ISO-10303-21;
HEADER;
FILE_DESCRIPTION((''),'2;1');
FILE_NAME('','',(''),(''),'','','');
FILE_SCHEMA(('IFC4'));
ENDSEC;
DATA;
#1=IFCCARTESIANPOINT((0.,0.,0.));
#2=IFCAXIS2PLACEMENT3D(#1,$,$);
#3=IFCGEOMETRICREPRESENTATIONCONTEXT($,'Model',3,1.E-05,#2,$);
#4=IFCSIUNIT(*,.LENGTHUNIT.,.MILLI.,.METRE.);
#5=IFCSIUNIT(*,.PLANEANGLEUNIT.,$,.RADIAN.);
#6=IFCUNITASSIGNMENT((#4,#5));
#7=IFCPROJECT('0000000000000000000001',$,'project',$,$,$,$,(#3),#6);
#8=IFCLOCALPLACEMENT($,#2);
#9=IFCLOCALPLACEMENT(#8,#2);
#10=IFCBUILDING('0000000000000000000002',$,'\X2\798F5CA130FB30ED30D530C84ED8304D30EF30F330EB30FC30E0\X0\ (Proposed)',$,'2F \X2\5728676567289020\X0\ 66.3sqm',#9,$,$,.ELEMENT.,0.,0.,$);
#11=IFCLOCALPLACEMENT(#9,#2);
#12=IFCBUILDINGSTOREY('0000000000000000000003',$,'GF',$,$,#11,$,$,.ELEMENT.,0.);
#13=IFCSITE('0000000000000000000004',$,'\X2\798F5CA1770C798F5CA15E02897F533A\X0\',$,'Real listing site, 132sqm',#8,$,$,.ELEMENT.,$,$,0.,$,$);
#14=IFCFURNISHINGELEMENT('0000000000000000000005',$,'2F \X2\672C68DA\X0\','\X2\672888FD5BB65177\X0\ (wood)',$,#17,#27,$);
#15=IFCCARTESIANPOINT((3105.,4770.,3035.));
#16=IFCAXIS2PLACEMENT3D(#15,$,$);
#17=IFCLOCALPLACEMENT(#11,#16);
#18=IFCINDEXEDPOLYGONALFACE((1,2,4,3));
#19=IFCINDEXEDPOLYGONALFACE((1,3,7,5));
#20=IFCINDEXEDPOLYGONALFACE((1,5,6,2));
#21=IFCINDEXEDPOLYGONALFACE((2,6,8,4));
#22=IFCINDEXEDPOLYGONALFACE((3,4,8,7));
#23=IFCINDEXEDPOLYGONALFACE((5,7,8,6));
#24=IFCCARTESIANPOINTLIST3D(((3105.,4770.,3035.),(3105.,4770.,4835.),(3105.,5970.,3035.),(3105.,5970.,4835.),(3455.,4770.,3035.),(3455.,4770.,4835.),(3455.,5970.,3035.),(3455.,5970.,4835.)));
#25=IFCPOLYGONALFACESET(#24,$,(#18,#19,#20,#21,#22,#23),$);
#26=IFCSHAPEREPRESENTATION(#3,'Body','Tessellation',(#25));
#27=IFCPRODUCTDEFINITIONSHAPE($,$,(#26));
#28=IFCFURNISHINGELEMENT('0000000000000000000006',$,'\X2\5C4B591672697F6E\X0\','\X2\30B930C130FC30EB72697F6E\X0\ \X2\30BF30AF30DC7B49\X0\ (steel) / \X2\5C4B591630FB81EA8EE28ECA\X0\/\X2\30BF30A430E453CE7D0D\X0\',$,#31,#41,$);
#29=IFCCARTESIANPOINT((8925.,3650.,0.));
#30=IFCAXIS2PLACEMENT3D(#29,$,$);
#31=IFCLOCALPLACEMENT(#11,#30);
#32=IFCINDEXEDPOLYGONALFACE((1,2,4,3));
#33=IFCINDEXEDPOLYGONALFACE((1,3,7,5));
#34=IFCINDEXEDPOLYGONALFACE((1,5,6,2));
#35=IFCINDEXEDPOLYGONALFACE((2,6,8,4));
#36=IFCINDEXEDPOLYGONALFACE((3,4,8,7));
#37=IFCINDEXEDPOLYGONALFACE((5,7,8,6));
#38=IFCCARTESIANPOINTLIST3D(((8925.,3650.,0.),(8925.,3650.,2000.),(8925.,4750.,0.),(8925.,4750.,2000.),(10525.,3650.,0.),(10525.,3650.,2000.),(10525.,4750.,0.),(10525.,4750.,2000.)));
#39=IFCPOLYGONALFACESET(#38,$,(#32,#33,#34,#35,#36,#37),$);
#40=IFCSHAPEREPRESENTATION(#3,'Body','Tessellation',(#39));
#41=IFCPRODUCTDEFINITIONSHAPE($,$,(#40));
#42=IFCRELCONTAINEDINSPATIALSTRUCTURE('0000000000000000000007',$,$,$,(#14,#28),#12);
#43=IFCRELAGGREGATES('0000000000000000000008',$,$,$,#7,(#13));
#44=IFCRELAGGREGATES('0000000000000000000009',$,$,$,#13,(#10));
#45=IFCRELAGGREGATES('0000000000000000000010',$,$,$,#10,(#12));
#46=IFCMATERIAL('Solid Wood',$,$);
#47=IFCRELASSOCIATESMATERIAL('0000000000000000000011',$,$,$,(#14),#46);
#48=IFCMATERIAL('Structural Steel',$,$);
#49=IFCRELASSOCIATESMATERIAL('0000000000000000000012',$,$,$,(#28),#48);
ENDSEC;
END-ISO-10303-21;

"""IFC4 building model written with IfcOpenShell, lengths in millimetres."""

from ifc_helpers import new_model, si_unit, frame, frame_2d, origin, place, context, project, spatial, rectangle, extrude, material, element, save


model = new_model("IFC4")

# Units and contexts
model_context = context("Model", 3, precision=1e-05, world=origin())
ifc_project = project(units=[si_unit("LENGTHUNIT", "METRE", prefix="MILLI"), si_unit("PLANEANGLEUNIT", "RADIAN")], contexts=[model_context])

# Site, building, storey
site_placement = place(None, origin())
site = spatial("IfcSite", under=ifc_project, at=site_placement, Name="福岡県福岡市西区", ObjectType="Real listing site, 132sqm", CompositionType="ELEMENT", RefElevation=0.0)
building_placement = place(site_placement, origin())
building = spatial("IfcBuilding", under=site, at=building_placement, Name="福岡・ロフト付きワンルーム (Proposed)", ObjectType="2F 在来木造 66.3sqm", CompositionType="ELEMENT", ElevationOfRefHeight=0.0, ElevationOfTerrain=0.0)
storey_placement = place(building_placement, origin())
storey = spatial("IfcBuildingStorey", under=building, at=storey_placement, Name="GF", CompositionType="ELEMENT", Elevation=0.0)

# Shared definitions
ifc_material_1 = material(Name="Solid Wood")

# Shared definitions
ifc_material_2 = material(Name="Structural Steel")

# Furnishing elements
furnishing_1_placement = place(storey_placement, frame((3105.0, 4770.0, 3035.0)))
element("IfcFurnishingElement", 1, at=furnishing_1_placement, inside=storey, material=ifc_material_1, Name="2F 本棚", Description="木製家具 (wood)", context=model_context, shape_type="SweptSolid", body=[
    extrude(rectangle(XDim=350.0, YDim=1200.0, at=frame_2d((175.0, 600.0))), frame((3105.0, 4770.0, 3035.0)), (0.0, 0.0, 1.0), 1800.0),
])
furnishing_2_placement = place(storey_placement, frame((8925.0, 3650.0, 0.0)))
element("IfcFurnishingElement", 2, at=furnishing_2_placement, inside=storey, material=ifc_material_2, Name="屋外物置", Description="スチール物置 タクボ等 (steel) / 屋外・自転車/タイヤ収納", context=model_context, shape_type="SweptSolid", body=[
    extrude(rectangle(XDim=1600.0, YDim=1100.0, at=frame_2d((800.0, 550.0))), frame((8925.0, 3650.0, 0.0)), (0.0, 0.0, 1.0), 2000.0),
])

save(model, "model.ifc")
